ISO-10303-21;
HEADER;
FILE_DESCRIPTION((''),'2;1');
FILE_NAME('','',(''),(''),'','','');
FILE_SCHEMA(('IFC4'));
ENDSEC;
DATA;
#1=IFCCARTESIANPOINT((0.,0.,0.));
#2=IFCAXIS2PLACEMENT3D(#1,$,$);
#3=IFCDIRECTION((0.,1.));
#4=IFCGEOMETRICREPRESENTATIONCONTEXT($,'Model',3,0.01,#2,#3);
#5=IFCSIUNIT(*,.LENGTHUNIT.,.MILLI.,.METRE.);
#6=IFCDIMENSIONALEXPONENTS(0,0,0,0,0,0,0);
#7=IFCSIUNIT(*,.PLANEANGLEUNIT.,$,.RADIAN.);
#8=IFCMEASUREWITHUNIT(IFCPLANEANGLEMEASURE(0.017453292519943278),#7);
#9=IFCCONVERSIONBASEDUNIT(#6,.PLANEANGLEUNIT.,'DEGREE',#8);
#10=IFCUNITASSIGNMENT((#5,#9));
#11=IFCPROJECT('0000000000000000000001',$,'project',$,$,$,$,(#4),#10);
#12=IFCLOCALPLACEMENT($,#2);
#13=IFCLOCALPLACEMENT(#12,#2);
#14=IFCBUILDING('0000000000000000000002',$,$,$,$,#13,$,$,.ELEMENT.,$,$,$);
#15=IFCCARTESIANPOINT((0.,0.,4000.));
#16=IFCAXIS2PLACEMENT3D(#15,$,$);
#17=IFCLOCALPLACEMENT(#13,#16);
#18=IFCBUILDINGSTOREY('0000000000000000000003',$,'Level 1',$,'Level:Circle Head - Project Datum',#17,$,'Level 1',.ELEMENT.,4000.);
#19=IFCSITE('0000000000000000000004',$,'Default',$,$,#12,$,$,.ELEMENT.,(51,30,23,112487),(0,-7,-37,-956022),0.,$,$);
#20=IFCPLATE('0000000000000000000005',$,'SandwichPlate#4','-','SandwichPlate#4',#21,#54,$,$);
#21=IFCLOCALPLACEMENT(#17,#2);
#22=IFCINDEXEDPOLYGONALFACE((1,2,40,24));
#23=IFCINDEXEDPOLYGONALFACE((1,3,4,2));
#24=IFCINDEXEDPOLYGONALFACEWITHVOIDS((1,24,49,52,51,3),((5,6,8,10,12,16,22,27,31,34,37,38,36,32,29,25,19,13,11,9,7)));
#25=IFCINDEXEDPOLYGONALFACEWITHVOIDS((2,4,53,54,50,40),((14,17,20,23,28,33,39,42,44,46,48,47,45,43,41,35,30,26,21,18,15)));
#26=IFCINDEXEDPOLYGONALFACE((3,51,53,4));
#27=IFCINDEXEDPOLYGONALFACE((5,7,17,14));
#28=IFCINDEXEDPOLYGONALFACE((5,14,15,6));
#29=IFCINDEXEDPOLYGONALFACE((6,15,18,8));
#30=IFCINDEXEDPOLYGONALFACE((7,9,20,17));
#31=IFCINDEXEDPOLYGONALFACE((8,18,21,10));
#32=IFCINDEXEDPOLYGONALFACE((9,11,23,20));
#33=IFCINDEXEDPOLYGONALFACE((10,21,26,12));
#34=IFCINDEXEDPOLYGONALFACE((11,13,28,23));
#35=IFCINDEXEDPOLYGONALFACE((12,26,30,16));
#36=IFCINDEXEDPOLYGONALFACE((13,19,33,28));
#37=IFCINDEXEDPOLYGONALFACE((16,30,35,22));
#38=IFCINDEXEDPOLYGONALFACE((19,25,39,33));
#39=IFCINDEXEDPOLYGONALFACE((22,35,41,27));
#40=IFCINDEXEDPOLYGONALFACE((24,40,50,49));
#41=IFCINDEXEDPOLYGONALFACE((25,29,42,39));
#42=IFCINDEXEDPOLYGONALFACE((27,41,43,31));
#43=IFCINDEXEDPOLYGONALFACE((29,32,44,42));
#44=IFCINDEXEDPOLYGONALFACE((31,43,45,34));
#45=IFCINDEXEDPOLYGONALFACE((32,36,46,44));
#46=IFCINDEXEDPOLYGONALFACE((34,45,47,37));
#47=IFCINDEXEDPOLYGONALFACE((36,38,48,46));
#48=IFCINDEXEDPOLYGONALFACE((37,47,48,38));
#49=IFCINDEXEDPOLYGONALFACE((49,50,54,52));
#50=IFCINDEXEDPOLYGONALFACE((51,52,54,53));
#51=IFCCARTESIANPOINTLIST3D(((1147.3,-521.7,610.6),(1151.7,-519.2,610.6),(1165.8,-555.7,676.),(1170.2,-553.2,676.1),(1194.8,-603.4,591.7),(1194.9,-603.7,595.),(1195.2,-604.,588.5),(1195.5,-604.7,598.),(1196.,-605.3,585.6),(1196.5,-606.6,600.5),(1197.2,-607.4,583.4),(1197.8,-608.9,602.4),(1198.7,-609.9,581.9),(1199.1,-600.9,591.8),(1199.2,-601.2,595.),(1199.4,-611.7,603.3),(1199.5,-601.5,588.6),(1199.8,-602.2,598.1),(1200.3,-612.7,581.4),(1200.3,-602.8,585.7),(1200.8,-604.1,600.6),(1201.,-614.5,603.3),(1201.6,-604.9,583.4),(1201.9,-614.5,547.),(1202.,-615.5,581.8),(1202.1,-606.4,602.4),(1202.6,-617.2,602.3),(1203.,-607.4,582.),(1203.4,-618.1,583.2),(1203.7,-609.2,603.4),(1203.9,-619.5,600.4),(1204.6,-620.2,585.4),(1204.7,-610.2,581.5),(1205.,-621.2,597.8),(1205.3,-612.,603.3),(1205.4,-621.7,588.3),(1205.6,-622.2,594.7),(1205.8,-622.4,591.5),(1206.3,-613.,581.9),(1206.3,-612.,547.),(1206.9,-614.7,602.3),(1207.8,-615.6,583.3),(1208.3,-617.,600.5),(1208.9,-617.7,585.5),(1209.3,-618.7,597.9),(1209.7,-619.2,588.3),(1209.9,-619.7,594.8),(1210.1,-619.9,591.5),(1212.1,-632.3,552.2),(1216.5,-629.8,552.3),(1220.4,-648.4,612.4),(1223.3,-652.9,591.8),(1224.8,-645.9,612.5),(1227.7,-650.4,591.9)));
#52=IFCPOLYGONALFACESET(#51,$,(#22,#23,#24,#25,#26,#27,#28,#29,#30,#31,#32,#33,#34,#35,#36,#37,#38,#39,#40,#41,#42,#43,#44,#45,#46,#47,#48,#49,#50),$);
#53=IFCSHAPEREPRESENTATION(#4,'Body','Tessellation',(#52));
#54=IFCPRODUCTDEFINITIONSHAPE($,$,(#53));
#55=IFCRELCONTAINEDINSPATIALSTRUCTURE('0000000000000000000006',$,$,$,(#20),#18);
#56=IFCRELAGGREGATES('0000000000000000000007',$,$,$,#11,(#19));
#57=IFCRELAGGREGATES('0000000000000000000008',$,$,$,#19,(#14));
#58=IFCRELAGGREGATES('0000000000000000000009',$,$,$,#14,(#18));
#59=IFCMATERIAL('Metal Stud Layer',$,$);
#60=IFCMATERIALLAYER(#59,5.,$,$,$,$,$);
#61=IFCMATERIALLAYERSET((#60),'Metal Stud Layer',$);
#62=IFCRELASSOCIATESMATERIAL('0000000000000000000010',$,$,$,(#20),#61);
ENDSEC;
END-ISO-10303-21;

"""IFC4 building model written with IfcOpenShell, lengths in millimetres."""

from ifc_helpers import new_model, entity, si_unit, converted_unit, direction, frame, origin, origin_with_axes, origin_2d_with_axis, place, context, project, spatial, polyline, circle, outline, extrude, material, layer, layer_set, element, save


model = new_model("IFC4")

# Units and contexts
model_context = context("Model", 3, precision=0.01, world=origin(), true_north=direction((0.0, 1.0)))
ifc_project = project(units=[si_unit("LENGTHUNIT", "METRE", prefix="MILLI"), converted_unit("PLANEANGLEUNIT", "DEGREE", entity("IfcPlaneAngleMeasure", 0.017453292519943278), si_unit("PLANEANGLEUNIT", "RADIAN"), dimensions=[0, 0, 0, 0, 0, 0, 0])], contexts=[model_context])

# Site, building, storey
site_placement = place(None, origin())
site = spatial("IfcSite", under=ifc_project, at=site_placement, Name="Default", CompositionType="ELEMENT", RefLatitude=(51, 30, 23, 112487), RefLongitude=(0, -7, -37, -956022), RefElevation=0.0)
building_placement = place(site_placement, origin())
building = spatial("IfcBuilding", under=site, at=building_placement, CompositionType="ELEMENT")
storey_placement = place(building_placement, frame((0.0, 0.0, 4000.0)))
storey = spatial("IfcBuildingStorey", under=building, at=storey_placement, Name="Level 1", ObjectType="Level:Circle Head - Project Datum", LongName="Level 1", CompositionType="ELEMENT", Elevation=4000.0)

# Shared definitions
ifc_material_1 = material(Name="Metal Stud Layer")

# Shared definitions
ifc_layer_1 = layer(ifc_material_1, 5.0)
ifc_layer_set_1 = layer_set([ifc_layer_1], Name="Metal Stud Layer")

# Plate, openings
plate_1_placement = place(storey_placement, frame((1212.8, -623.1, 539.4), z_axis=(-0.865935, -0.499948, -0.014432), x_axis=(0.243701, -0.44695, 0.860724)))
plate_1 = element("IfcPlate", 1, at=plate_1_placement, inside=storey, material=ifc_layer_set_1, Name="SandwichPlate#4", Description="-", ObjectType="SandwichPlate#4", context=model_context, shape_type="SweptSolid", body=[
    extrude(outline(polyline([(0.0, 0.0), (76.0, 0.0), (76.0, 140.0), (0.0, 140.0), (0.0, 0.0)])), origin_with_axes(), (0.0, 0.0, 1.0), 5.0),
])
opening_1_placement = place(plate_1_placement, frame((0.0, 0.0, 0.0), z_axis=(0.0, 0.0, 1.0), x_axis=(1.0, 0.0, 0.0)))
element("IfcOpeningElement", 2, at=opening_1_placement, cuts=plate_1, ObjectType="Opening", context=model_context, shape_type="SweptSolid", body=[
    extrude(outline(polyline([(0.0, 0.0), (15.0, 0.0), (0.0, 15.0), (0.0, 0.0)])), origin(), (0.0, 0.0, 1.0), 5.0),
])
opening_2_placement = place(plate_1_placement, frame((0.0, 0.0, 0.0), z_axis=(0.0, 0.0, 1.0), x_axis=(1.0, 0.0, 0.0)))
element("IfcOpeningElement", 3, at=opening_2_placement, cuts=plate_1, ObjectType="Opening", context=model_context, shape_type="SweptSolid", body=[
    extrude(outline(polyline([(76.0, 0.0), (76.0, 15.0), (61.0, 0.0), (76.0, 0.0)])), origin(), (0.0, 0.0, 1.0), 5.0),
])
opening_3_placement = place(plate_1_placement, frame((38.0, 40.0, -0.5), z_axis=(0.0, 0.0, 1.0), x_axis=(0.0, 1.0, 0.0)))
element("IfcOpeningElement", 4, at=opening_3_placement, cuts=plate_1, ObjectType="Opening", context=model_context, shape_type="SweptSolid", body=[
    extrude(circle(Radius=11.0, at=origin_2d_with_axis()), origin(), (0.0, 0.0, 1.0), 6.0),
])

save(model, "model.ifc")
